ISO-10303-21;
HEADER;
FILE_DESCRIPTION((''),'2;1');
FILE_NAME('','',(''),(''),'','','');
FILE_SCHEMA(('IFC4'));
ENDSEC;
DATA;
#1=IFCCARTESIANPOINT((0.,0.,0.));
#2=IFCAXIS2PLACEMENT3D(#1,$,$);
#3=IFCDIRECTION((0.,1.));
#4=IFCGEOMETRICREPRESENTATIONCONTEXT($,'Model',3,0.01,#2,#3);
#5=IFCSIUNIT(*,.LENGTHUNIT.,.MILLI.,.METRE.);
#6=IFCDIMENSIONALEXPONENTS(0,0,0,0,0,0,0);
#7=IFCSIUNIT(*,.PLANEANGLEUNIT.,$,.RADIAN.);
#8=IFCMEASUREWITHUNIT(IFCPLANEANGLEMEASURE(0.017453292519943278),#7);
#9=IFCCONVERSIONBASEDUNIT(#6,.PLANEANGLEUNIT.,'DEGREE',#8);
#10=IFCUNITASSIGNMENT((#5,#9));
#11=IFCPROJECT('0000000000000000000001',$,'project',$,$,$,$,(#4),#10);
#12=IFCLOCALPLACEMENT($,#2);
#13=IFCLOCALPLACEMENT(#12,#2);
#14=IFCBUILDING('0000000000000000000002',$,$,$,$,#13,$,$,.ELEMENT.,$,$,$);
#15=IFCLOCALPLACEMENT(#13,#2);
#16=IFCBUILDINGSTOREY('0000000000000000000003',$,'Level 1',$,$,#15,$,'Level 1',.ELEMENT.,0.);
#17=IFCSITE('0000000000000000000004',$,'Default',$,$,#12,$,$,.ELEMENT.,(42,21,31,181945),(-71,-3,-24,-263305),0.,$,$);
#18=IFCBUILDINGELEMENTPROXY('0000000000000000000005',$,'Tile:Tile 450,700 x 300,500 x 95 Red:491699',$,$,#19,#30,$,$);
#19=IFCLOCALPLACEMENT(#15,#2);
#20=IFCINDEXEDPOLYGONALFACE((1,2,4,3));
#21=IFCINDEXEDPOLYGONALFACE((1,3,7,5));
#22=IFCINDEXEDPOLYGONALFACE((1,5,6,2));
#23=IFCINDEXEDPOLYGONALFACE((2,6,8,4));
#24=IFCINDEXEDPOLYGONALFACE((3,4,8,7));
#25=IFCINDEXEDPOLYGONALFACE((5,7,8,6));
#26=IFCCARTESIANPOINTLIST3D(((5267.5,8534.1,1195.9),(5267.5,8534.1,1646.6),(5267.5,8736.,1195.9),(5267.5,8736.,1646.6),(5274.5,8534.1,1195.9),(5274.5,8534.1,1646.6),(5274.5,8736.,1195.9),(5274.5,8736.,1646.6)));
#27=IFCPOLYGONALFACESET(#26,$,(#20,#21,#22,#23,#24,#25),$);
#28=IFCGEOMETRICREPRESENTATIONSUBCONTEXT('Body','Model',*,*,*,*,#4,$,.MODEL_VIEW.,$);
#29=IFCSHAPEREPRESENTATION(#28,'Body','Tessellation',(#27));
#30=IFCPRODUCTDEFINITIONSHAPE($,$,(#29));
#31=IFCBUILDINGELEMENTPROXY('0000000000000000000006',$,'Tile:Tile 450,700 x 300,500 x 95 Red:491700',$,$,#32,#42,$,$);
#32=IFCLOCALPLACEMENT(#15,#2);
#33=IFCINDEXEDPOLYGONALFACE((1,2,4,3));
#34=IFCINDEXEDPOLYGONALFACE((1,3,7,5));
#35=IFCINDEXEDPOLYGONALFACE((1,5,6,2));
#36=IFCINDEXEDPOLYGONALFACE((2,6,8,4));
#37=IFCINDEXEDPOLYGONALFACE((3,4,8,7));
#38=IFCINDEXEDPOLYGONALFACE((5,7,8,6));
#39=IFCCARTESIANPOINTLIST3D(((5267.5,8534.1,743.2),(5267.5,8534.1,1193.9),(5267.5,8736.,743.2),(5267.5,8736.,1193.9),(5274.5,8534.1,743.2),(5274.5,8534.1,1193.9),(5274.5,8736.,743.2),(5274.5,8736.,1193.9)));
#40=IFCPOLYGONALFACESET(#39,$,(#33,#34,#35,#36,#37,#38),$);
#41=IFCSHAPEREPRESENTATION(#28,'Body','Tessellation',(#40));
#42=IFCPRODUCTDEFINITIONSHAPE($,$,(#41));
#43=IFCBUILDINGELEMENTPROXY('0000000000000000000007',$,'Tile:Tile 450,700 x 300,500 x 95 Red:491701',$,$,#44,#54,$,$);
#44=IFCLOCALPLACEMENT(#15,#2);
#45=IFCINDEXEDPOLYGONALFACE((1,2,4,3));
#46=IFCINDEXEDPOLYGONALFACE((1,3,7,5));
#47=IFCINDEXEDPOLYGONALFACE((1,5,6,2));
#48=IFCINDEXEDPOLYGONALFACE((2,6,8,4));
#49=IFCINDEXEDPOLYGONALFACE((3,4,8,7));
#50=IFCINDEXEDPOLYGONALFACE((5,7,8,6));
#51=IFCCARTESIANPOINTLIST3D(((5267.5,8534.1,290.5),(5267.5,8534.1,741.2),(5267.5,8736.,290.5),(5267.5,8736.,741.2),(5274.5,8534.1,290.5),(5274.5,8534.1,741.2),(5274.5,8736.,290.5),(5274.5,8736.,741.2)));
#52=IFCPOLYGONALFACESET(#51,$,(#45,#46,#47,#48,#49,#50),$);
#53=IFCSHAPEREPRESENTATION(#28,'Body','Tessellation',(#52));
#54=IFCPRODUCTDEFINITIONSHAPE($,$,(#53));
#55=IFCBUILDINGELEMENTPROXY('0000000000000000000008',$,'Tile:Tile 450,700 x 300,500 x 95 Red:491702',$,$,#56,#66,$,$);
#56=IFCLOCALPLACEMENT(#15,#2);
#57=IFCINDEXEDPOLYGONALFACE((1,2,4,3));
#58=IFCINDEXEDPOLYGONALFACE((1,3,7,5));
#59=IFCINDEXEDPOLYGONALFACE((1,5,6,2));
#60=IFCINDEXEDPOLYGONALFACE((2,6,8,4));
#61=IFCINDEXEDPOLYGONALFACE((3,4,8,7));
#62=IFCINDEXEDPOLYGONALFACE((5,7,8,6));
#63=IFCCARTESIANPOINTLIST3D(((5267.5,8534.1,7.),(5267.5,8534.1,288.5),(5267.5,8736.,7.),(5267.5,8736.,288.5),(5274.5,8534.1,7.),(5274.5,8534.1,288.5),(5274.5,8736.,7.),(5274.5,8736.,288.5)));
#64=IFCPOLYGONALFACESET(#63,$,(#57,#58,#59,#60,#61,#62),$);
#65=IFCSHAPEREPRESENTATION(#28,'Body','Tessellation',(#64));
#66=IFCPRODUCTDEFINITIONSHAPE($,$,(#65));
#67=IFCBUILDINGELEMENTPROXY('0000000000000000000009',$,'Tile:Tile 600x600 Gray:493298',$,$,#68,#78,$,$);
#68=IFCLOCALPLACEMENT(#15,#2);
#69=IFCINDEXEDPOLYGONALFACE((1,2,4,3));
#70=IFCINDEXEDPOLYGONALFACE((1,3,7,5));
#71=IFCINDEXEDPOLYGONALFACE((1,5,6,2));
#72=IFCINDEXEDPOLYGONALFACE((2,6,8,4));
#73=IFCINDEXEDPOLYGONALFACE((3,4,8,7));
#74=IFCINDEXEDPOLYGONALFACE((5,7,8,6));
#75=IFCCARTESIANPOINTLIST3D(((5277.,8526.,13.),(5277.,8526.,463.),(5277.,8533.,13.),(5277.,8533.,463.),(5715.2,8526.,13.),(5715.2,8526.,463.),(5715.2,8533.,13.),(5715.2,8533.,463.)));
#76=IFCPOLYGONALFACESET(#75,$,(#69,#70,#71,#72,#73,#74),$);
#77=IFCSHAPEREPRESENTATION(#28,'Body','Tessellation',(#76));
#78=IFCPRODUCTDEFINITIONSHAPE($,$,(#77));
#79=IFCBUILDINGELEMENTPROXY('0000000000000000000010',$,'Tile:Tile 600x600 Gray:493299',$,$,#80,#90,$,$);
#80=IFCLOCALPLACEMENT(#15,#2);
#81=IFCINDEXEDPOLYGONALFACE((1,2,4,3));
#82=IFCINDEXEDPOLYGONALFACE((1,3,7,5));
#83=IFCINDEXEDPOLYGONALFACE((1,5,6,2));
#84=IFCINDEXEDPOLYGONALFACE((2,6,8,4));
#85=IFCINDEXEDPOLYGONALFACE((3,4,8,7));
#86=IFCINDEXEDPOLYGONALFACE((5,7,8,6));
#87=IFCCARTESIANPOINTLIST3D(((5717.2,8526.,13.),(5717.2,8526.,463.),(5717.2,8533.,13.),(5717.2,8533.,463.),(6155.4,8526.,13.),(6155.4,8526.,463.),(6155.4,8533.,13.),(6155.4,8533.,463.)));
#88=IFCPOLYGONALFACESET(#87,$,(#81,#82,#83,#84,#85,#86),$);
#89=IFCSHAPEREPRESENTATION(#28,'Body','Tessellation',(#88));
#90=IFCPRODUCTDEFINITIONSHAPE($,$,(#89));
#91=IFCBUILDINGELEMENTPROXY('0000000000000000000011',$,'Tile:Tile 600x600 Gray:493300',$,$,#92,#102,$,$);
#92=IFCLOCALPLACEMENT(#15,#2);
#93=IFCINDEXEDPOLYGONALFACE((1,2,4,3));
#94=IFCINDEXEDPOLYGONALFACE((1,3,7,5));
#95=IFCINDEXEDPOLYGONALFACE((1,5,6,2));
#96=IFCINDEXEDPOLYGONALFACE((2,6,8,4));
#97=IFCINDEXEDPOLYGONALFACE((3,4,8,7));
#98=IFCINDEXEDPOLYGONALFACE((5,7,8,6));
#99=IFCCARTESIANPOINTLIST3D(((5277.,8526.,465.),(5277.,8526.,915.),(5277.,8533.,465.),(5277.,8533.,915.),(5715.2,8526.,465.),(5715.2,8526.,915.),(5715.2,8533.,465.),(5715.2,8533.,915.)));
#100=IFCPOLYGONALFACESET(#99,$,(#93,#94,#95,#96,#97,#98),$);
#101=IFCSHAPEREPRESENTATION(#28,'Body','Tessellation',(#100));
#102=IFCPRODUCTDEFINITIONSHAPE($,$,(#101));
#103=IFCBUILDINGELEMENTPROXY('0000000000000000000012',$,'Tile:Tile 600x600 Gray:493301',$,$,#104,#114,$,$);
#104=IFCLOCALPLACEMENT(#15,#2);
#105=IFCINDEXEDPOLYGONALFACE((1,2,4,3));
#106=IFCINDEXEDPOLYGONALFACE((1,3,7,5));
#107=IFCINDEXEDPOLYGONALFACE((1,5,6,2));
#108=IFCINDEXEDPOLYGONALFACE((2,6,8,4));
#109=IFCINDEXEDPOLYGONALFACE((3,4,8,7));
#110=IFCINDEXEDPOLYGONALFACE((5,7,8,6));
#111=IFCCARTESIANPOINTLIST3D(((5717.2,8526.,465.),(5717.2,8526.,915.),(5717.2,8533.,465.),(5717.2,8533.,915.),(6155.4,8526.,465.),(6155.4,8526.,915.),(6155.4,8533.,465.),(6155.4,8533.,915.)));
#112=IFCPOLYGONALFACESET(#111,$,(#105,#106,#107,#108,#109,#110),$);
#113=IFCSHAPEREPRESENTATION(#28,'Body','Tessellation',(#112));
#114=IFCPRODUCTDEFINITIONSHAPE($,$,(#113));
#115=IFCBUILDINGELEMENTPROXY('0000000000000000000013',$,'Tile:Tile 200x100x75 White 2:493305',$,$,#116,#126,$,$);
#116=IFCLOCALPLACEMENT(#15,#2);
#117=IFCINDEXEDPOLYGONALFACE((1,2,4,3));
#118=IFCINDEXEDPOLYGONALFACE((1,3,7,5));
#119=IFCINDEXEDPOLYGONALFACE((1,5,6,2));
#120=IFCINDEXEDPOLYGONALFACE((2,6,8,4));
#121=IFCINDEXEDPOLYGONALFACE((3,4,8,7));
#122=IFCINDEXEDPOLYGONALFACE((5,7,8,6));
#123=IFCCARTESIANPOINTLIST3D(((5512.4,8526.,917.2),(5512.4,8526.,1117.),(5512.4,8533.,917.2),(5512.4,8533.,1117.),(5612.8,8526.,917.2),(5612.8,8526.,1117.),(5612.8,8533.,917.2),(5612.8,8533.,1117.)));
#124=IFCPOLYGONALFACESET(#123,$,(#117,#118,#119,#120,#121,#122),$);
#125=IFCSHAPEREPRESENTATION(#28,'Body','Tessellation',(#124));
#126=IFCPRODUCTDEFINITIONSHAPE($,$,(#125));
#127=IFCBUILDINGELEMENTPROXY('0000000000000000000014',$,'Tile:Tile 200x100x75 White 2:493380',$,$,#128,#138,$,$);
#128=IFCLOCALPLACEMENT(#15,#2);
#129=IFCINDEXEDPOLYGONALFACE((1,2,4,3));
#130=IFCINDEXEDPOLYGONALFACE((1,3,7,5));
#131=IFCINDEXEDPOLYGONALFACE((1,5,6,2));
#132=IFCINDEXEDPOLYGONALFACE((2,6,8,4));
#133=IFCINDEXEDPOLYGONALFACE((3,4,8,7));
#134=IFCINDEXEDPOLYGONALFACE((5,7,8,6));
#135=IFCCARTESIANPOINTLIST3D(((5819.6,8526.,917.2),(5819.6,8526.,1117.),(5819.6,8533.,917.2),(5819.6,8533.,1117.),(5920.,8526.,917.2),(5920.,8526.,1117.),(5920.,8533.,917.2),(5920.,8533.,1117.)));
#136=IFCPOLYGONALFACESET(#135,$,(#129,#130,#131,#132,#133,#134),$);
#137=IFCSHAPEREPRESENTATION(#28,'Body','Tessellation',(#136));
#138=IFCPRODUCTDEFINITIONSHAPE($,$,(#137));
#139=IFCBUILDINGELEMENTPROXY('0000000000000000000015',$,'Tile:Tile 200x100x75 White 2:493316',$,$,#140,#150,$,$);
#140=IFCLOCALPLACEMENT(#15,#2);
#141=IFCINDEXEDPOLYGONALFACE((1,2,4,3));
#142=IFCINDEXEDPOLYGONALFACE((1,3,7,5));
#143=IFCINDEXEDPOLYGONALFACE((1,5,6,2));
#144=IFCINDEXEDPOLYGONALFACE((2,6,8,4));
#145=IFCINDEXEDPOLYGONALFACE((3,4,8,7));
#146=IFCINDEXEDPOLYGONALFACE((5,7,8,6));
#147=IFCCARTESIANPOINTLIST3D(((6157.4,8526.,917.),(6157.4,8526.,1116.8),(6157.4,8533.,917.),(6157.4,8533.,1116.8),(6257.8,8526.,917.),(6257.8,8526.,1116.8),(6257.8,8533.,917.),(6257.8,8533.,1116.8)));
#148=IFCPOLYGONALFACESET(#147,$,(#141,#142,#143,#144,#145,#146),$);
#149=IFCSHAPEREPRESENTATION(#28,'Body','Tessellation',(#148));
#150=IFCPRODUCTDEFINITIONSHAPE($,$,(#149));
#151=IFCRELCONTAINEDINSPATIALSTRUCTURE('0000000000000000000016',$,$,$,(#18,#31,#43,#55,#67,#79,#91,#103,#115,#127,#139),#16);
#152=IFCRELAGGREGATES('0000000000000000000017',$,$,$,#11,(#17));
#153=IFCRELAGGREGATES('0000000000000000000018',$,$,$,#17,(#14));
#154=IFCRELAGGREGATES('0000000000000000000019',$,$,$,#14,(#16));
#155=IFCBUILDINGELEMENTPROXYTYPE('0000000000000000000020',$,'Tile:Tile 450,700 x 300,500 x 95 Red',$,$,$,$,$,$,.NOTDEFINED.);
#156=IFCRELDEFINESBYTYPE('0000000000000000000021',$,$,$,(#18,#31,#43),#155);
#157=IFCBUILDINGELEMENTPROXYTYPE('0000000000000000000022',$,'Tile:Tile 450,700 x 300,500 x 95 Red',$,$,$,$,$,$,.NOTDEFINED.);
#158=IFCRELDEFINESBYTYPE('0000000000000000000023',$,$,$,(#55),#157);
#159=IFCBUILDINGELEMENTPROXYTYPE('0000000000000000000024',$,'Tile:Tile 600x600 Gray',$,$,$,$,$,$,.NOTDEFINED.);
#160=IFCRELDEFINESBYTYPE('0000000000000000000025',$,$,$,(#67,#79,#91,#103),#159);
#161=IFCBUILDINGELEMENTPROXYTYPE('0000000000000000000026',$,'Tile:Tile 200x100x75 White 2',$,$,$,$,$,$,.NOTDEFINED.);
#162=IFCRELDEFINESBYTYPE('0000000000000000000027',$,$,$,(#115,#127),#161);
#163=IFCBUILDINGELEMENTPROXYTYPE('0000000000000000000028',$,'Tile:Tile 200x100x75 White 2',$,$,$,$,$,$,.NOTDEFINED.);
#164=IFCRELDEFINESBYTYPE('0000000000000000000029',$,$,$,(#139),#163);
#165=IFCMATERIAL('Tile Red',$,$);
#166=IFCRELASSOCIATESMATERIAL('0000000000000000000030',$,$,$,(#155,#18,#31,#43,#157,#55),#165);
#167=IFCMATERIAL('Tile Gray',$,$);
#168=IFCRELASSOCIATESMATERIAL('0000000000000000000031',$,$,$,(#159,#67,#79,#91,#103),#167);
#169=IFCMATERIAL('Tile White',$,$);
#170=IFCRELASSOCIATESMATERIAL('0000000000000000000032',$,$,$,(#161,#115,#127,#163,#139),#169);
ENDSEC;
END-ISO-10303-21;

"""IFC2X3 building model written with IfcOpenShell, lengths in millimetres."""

from ifc_helpers import new_model, entity, si_unit, converted_unit, direction, frame, frame_2d, origin, origin_2d_with_axis, place, context, subcontext, project, spatial, rectangle, extrude, source, transform, mapped, material, type_object, type_shapes, element, save


model = new_model("IFC2X3")

# Units and contexts
model_context = context("Model", 3, precision=0.01, world=origin(), true_north=direction((0.0, 1.0)))
body_context = subcontext(model_context, "Body", "Model", "MODEL_VIEW")
ifc_project = project(units=[si_unit("LENGTHUNIT", "METRE", prefix="MILLI"), converted_unit("PLANEANGLEUNIT", "DEGREE", entity("IfcPlaneAngleMeasure", 0.017453292519943278), si_unit("PLANEANGLEUNIT", "RADIAN"), dimensions=[0, 0, 0, 0, 0, 0, 0])], contexts=[model_context])

# Site, building, storey
site_placement = place(None, origin())
site = spatial("IfcSite", under=ifc_project, at=site_placement, Name="Default", CompositionType="ELEMENT", RefLatitude=(42, 21, 31, 181945), RefLongitude=(-71, -3, -24, -263305), RefElevation=0.0)
building_placement = place(site_placement, origin())
building = spatial("IfcBuilding", under=site, at=building_placement, CompositionType="ELEMENT")
storey_placement = place(building_placement, origin())
storey = spatial("IfcBuildingStorey", under=building, at=storey_placement, Name="Level 1", LongName="Level 1", CompositionType="ELEMENT", Elevation=0.0)

# Building element proxies
ifc_material_1 = material(Name="Tile Red")
building_element_proxy_type_1 = type_object("IfcBuildingElementProxyType", Name="Tile:Tile 450,700 x 300,500 x 95 Red", PredefinedType="NOTDEFINED", material=ifc_material_1)
shared_shape_1 = source(origin(), body_context, "Body", "SweptSolid", [
    extrude(rectangle(XDim=202.0, YDim=450.7, at=frame_2d((0.0, 0.0), x_axis=(1.0, 0.0))), frame((-101.0, -225.4, 0.0), z_axis=(0.0, 0.0, 1.0), x_axis=(-1.0, 0.0, 0.0)), (0.0, 0.0, 1.0), 7.0),
])
type_shapes(building_element_proxy_type_1, [shared_shape_1])
for number, where, z_axis, x_axis, name in (
    (1, (5274.5, 8736.0, 1195.9), (-1.0, 0.0, 0.0), (0.0, 1.0, 0.0), "Tile:Tile 450,700 x 300,500 x 95 Red:491699"),
    (2, (5274.5, 8736.0, 743.2), (-1.0, 0.0, 0.0), (0.0, 1.0, 0.0), "Tile:Tile 450,700 x 300,500 x 95 Red:491700"),
    (3, (5274.5, 8736.0, 290.5), (-1.0, 0.0, 0.0), (0.0, 1.0, 0.0), "Tile:Tile 450,700 x 300,500 x 95 Red:491701"),
):
    element("IfcBuildingElementProxy", number, at=place(storey_placement, frame(where, z_axis=z_axis, x_axis=x_axis)), inside=storey, type_object=building_element_proxy_type_1, material=ifc_material_1, Name=name, context=body_context, shape_type="MappedRepresentation", body=[
        mapped(shared_shape_1, transform((0.0, 0.0, 0.0), scale=1.0)),
    ])
building_element_proxy_type_2 = type_object("IfcBuildingElementProxyType", Name="Tile:Tile 450,700 x 300,500 x 95 Red", PredefinedType="NOTDEFINED", material=ifc_material_1)
shared_shape_2 = source(origin(), body_context, "Body", "SweptSolid", [
    extrude(rectangle(XDim=202.0, YDim=281.4, at=frame_2d((0.0, 0.0), x_axis=(1.0, 0.0))), frame((-101.0, -140.7, 0.0), z_axis=(0.0, 0.0, 1.0), x_axis=(-1.0, 0.0, 0.0)), (0.0, 0.0, 1.0), 7.0),
])
type_shapes(building_element_proxy_type_2, [shared_shape_2])
proxy_1_placement = place(storey_placement, frame((5274.5, 8736.0, 7.0), z_axis=(-1.0, 0.0, 0.0), x_axis=(0.0, 1.0, 0.0)))
element("IfcBuildingElementProxy", 4, at=proxy_1_placement, inside=storey, type_object=building_element_proxy_type_2, material=ifc_material_1, Name="Tile:Tile 450,700 x 300,500 x 95 Red:491702", context=body_context, shape_type="MappedRepresentation", body=[
    mapped(shared_shape_2, transform((0.0, 0.0, 0.0), scale=1.0)),
])
ifc_material_2 = material(Name="Tile Gray")
building_element_proxy_type_3 = type_object("IfcBuildingElementProxyType", Name="Tile:Tile 600x600 Gray", PredefinedType="NOTDEFINED", material=ifc_material_2)
shared_shape_3 = source(origin(), body_context, "Body", "SweptSolid", [
    extrude(rectangle(XDim=438.2, YDim=450.0, at=origin_2d_with_axis()), frame((-219.1, -225.0, 0.0), z_axis=(0.0, 0.0, 1.0), x_axis=(-1.0, 0.0, 0.0)), (0.0, 0.0, 1.0), 7.0),
])
type_shapes(building_element_proxy_type_3, [shared_shape_3])
for number, where, z_axis, x_axis, name in (
    (5, (5715.2, 8533.0, 463.0), (0.0, -1.0, 0.0), (1.0, 0.0, 0.0), "Tile:Tile 600x600 Gray:493298"),
    (6, (6155.4, 8533.0, 463.0), (0.0, -1.0, 0.0), (1.0, 0.0, 0.0), "Tile:Tile 600x600 Gray:493299"),
    (7, (5715.2, 8533.0, 915.0), (0.0, -1.0, 0.0), (1.0, 0.0, 0.0), "Tile:Tile 600x600 Gray:493300"),
    (8, (6155.4, 8533.0, 915.0), (0.0, -1.0, 0.0), (1.0, 0.0, 0.0), "Tile:Tile 600x600 Gray:493301"),
):
    element("IfcBuildingElementProxy", number, at=place(storey_placement, frame(where, z_axis=z_axis, x_axis=x_axis)), inside=storey, type_object=building_element_proxy_type_3, material=ifc_material_2, Name=name, context=body_context, shape_type="MappedRepresentation", body=[
        mapped(shared_shape_3, transform((0.0, 0.0, 0.0), scale=1.0)),
    ])
ifc_material_3 = material(Name="Tile White")
building_element_proxy_type_4 = type_object("IfcBuildingElementProxyType", Name="Tile:Tile 200x100x75 White 2", PredefinedType="NOTDEFINED", material=ifc_material_3)
shared_shape_4 = source(origin(), body_context, "Body", "SweptSolid", [
    extrude(rectangle(XDim=199.8, YDim=100.4, at=frame_2d((0.0, 0.0), x_axis=(1.0, 0.0))), frame((-50.2, -99.9, 0.0), z_axis=(0.0, 0.0, 1.0), x_axis=(0.0, -1.0, 0.0)), (0.0, 0.0, 1.0), 7.0),
])
type_shapes(building_element_proxy_type_4, [shared_shape_4])
for number, where, z_axis, x_axis, name in (
    (9, (5612.8, 8533.0, 1117.0), (0.0, -1.0, 0.0), (1.0, 0.0, 0.0), "Tile:Tile 200x100x75 White 2:493305"),
    (10, (5920.0, 8533.0, 1117.0), (0.0, -1.0, 0.0), (1.0, 0.0, 0.0), "Tile:Tile 200x100x75 White 2:493380"),
):
    element("IfcBuildingElementProxy", number, at=place(storey_placement, frame(where, z_axis=z_axis, x_axis=x_axis)), inside=storey, type_object=building_element_proxy_type_4, material=ifc_material_3, Name=name, context=body_context, shape_type="MappedRepresentation", body=[
        mapped(shared_shape_4, transform((0.0, 0.0, 0.0), scale=1.0)),
    ])
building_element_proxy_type_5 = type_object("IfcBuildingElementProxyType", Name="Tile:Tile 200x100x75 White 2", PredefinedType="NOTDEFINED", material=ifc_material_3)
shared_shape_5 = source(origin(), body_context, "Body", "SweptSolid", [
    extrude(rectangle(XDim=199.8, YDim=100.4, at=frame_2d((0.0, 0.0), x_axis=(1.0, 0.0))), frame((-50.2, -99.9, 0.0), z_axis=(0.0, 0.0, 1.0), x_axis=(0.0, -1.0, 0.0)), (0.0, 0.0, 1.0), 7.0),
])
type_shapes(building_element_proxy_type_5, [shared_shape_5])
proxy_2_placement = place(storey_placement, frame((6257.8, 8533.0, 1116.8), z_axis=(0.0, -1.0, 0.0), x_axis=(1.0, 0.0, 0.0)))
element("IfcBuildingElementProxy", 11, at=proxy_2_placement, inside=storey, type_object=building_element_proxy_type_5, material=ifc_material_3, Name="Tile:Tile 200x100x75 White 2:493316", context=body_context, shape_type="MappedRepresentation", body=[
    mapped(shared_shape_5, transform((0.0, 0.0, 0.0), scale=1.0)),
])

save(model, "model.ifc")
